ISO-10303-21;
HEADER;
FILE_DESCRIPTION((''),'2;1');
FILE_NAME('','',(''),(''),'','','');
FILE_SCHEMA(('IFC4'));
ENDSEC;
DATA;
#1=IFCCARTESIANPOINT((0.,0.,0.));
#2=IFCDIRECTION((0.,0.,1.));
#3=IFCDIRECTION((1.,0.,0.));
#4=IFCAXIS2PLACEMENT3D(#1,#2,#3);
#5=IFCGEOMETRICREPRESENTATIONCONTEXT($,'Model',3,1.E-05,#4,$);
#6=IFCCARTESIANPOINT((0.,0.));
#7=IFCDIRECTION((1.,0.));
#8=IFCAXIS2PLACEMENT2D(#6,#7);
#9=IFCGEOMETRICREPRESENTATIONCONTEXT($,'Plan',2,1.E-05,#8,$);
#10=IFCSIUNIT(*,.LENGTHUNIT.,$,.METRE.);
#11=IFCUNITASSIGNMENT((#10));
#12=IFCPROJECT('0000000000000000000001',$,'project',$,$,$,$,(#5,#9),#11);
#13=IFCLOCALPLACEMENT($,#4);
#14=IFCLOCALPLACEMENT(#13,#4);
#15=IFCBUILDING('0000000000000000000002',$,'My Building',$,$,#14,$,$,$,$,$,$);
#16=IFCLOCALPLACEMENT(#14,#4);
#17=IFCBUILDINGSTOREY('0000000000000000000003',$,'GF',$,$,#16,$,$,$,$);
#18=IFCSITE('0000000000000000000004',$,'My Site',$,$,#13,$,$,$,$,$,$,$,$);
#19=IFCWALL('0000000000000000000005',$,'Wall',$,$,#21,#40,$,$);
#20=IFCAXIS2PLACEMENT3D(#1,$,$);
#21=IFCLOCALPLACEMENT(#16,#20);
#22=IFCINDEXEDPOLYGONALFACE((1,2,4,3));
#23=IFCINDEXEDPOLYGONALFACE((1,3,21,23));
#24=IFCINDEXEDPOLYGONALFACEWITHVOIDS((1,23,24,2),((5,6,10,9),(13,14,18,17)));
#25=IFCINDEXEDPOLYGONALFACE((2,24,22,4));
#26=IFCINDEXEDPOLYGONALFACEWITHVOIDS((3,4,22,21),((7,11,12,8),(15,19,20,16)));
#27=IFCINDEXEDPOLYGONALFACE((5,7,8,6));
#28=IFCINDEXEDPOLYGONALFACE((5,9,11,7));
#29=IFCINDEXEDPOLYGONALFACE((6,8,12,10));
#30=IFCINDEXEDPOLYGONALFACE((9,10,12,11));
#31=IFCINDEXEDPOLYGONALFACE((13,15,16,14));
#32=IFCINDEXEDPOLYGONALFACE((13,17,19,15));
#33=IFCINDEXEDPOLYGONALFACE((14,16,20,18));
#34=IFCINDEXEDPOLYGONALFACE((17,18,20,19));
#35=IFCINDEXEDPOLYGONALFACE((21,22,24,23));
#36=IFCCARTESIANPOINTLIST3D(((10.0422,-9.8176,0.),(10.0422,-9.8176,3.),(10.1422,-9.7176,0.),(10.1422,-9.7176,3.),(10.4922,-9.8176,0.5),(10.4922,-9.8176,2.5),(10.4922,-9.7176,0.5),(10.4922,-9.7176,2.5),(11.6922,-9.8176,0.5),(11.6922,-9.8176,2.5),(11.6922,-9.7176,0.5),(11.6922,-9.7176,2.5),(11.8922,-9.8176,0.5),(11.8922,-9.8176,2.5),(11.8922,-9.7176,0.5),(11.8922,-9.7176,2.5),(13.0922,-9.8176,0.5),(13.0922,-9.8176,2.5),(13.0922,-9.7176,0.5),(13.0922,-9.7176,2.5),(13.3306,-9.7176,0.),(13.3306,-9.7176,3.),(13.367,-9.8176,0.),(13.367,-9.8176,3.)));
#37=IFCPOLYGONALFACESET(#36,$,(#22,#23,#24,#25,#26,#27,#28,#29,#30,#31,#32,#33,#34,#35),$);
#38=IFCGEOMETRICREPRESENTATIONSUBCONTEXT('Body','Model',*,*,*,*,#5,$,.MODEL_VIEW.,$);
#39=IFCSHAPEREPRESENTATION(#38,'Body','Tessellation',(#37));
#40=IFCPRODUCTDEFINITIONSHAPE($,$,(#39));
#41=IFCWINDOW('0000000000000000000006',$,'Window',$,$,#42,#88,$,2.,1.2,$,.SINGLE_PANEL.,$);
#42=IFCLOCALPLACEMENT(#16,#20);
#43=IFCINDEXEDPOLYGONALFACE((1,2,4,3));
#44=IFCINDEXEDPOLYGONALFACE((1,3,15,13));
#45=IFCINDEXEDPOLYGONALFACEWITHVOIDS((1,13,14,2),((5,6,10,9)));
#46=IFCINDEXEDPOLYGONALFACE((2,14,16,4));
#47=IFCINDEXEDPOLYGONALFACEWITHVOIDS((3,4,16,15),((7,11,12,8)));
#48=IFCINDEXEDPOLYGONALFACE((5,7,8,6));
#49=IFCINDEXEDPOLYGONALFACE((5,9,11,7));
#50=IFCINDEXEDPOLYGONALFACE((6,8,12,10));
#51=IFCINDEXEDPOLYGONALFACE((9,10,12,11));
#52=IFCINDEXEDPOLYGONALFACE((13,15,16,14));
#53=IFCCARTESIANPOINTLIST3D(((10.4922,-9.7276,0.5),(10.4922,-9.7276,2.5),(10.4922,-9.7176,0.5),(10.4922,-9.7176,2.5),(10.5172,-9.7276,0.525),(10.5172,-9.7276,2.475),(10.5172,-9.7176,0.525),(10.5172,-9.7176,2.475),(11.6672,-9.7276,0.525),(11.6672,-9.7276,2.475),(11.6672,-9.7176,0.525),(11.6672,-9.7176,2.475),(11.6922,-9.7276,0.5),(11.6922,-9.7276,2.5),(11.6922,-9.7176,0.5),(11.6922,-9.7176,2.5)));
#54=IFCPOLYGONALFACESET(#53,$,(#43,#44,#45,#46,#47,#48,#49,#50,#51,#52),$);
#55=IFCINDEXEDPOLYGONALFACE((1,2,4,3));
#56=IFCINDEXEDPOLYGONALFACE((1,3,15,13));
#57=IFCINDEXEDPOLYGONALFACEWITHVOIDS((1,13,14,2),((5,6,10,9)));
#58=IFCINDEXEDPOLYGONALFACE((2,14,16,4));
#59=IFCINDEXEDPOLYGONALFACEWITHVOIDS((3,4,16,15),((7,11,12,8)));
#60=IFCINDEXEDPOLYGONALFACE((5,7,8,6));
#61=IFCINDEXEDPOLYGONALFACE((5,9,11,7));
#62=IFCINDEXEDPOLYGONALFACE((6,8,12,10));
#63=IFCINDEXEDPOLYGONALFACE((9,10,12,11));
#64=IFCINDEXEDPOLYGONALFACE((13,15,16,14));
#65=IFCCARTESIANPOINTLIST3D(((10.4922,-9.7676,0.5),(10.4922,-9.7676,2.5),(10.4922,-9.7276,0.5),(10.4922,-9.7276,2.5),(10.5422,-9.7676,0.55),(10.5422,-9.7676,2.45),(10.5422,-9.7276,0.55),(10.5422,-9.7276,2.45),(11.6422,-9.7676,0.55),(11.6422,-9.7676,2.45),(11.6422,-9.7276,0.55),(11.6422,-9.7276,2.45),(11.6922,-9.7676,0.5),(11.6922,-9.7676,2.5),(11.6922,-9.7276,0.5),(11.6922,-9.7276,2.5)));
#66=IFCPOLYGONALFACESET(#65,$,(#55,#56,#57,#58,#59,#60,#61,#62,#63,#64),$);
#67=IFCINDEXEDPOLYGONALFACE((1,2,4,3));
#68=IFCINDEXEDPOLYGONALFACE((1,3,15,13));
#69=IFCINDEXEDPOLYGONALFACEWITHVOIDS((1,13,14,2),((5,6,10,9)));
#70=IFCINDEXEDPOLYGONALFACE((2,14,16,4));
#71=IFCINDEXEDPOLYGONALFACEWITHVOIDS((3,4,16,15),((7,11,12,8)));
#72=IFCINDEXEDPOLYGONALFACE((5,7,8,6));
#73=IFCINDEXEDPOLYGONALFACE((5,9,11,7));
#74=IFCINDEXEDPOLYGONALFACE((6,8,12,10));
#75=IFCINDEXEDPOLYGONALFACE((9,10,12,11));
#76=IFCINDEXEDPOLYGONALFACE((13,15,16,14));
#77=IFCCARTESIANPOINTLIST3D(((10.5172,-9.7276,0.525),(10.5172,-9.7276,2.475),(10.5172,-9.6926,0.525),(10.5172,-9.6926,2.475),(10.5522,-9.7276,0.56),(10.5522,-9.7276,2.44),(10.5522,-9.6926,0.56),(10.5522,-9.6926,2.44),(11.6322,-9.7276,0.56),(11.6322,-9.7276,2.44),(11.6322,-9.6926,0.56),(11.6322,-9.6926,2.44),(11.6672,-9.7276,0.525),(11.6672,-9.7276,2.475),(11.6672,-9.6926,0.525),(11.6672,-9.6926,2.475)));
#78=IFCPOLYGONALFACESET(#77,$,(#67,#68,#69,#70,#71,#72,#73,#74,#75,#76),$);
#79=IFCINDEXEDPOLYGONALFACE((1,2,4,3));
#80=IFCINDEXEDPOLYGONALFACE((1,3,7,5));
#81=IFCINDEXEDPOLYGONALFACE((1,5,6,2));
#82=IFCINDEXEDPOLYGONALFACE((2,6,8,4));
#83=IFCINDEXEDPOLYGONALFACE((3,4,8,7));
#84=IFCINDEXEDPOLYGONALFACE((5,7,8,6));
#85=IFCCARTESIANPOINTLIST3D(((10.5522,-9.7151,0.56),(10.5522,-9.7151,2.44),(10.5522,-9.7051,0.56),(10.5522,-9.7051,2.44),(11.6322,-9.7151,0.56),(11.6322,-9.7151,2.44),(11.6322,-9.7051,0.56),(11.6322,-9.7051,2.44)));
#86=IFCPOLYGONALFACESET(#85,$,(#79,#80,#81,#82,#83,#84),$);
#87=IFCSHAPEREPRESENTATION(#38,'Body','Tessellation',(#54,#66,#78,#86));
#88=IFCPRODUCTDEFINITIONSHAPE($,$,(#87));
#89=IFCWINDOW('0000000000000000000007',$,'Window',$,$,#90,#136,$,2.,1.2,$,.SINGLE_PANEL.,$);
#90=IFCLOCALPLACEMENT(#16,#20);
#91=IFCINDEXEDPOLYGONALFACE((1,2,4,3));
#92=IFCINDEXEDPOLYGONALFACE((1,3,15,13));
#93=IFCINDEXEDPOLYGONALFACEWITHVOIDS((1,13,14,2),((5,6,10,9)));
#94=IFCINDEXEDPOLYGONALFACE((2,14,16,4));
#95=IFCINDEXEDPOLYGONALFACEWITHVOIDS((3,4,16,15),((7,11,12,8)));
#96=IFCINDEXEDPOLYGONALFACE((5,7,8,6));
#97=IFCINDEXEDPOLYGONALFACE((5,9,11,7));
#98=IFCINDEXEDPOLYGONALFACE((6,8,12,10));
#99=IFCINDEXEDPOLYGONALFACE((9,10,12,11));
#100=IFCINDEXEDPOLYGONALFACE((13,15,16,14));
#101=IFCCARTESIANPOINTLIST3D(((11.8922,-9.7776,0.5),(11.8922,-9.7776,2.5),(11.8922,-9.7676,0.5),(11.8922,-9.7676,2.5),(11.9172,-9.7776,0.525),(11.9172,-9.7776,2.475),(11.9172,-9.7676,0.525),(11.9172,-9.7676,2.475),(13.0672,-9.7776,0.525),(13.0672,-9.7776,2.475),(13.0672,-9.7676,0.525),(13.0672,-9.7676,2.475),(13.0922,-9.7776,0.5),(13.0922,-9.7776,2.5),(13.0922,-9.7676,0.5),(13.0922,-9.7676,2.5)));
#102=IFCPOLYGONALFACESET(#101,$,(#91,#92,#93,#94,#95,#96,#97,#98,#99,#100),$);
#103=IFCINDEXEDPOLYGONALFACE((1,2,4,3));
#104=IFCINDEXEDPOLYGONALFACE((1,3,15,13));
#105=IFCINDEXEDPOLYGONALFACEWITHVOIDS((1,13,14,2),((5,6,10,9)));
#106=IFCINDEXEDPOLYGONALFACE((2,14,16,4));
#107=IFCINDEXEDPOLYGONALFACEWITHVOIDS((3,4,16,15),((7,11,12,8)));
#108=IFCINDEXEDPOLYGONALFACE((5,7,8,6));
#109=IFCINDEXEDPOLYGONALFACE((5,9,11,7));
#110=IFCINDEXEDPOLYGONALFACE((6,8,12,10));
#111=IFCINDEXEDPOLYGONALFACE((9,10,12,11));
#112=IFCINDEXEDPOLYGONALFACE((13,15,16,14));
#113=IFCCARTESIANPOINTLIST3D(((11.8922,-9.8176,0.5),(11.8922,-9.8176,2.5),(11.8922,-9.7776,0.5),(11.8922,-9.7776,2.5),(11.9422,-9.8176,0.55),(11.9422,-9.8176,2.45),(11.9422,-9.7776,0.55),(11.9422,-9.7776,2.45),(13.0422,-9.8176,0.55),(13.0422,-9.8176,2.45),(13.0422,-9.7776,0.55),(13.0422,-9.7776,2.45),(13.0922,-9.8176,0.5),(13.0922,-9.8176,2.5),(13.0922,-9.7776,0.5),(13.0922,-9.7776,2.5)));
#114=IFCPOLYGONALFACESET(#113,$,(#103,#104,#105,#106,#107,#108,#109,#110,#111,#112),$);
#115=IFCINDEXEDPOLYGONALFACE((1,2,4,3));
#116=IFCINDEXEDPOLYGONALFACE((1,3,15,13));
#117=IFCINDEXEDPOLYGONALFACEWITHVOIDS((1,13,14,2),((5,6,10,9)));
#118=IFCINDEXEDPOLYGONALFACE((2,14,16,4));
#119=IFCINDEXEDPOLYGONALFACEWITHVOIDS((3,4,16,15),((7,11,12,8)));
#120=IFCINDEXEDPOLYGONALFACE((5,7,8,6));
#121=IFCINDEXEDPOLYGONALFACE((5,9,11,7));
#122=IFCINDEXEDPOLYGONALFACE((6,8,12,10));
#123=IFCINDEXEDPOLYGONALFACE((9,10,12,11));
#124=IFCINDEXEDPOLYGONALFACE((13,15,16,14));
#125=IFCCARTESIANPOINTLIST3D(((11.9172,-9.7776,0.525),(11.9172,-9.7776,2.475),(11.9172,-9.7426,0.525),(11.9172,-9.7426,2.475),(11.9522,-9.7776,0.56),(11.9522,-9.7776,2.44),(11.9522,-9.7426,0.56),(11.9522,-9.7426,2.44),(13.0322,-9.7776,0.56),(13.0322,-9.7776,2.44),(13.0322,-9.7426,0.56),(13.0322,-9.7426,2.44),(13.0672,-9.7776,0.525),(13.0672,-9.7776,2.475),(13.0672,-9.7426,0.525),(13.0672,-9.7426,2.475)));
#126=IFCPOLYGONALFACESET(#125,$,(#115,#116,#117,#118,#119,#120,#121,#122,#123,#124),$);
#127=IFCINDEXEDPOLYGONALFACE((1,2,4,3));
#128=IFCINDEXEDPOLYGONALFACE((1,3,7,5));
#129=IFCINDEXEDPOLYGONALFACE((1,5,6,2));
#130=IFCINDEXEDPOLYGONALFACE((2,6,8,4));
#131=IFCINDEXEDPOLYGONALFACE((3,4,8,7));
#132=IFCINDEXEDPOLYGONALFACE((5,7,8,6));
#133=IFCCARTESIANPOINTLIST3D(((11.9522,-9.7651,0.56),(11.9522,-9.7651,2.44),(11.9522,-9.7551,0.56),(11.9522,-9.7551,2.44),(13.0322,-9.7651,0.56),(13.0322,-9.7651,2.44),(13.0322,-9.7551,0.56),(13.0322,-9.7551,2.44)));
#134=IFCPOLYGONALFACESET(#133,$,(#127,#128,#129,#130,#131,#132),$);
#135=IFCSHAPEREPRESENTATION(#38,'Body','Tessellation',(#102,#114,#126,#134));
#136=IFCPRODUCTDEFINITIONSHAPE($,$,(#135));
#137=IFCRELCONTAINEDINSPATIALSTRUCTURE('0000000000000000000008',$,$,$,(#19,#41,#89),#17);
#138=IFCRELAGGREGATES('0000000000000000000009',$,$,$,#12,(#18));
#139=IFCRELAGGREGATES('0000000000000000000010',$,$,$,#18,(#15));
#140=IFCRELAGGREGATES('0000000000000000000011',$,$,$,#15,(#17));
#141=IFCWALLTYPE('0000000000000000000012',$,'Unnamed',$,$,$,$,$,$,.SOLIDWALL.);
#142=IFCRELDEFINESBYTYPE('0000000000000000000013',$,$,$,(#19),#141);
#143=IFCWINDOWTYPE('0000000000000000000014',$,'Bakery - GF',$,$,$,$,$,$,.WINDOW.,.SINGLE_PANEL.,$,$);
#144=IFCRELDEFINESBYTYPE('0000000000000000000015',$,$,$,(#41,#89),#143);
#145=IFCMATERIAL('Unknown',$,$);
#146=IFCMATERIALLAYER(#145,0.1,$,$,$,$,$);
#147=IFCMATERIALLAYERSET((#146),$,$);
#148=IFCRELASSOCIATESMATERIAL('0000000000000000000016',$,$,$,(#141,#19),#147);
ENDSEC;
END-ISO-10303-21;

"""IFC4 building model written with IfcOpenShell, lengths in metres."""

from ifc_helpers import new_model, entity, si_unit, frame, origin_with_axes, origin_2d_with_axis, place, context, subcontext, project, spatial, line, indexed_curve, outline, extrude, shape, source, transform, mapped, material, layer, layer_set, layer_usage, type_object, type_shapes, element, fill, save


model = new_model("IFC4")

# Units and contexts
model_context = context("Model", 3, precision=1e-05, world=origin_with_axes())
plan_context = context("Plan", 2, precision=1e-05, world=origin_2d_with_axis())
body_context_1 = subcontext(model_context, "Body", "Model", "MODEL_VIEW")
body_context_2 = subcontext(plan_context, "Body", "Plan", "PLAN_VIEW")
ifc_project = project(units=[si_unit("LENGTHUNIT", "METRE")], contexts=[model_context, plan_context])

# Site, building, storey
site_placement = place(None, origin_with_axes())
site = spatial("IfcSite", under=ifc_project, at=site_placement, Name="My Site")
building_placement = place(site_placement, origin_with_axes())
building = spatial("IfcBuilding", under=site, at=building_placement, Name="My Building")
storey_placement = place(building_placement, origin_with_axes())
storey = spatial("IfcBuildingStorey", under=building, at=storey_placement, Name="GF")

# Shared definitions
ifc_material = material(Name="Unknown")

# Shared definitions
ifc_layer_1 = layer(ifc_material, 0.1)
ifc_layer_set_1 = layer_set([ifc_layer_1])
wall_type = type_object("IfcWallType", Name="Unnamed", PredefinedType="SOLIDWALL", material=ifc_layer_set_1)

# Wall, openings, windows
ifc_layer_usage_1 = layer_usage(ifc_layer_set_1, "AXIS2", "POSITIVE", 0.0)
wall_1_placement = place(storey_placement, frame((10.1422, -9.8176, 0.0), z_axis=(0.0, 0.0, 1.0), x_axis=(1.0, 0.0, 0.0)))
wall_1 = element("IfcWall", 1, at=wall_1_placement, inside=storey, type_object=wall_type, material=ifc_layer_usage_1, Name="Wall", context=body_context_1, shape_type="SweptSolid", body=[
    extrude(outline(indexed_curve([(-0.1, 0.0), (0.0, 0.1), (3.1883, 0.1), (3.2247, 0.0)], segments=[line(1, 2, 3, 4, 1)])), origin_with_axes(), (0.0, 0.0, 1.0), 3.0),
])
shared_shape_1 = source(origin_with_axes(), body_context_1, "Body", "SweptSolid", [
    extrude(outline(indexed_curve([(0.0, 0.0), (1.2, 0.0), (1.2, 2.0), (0.0, 2.0)], segments=[line(1, 2, 3, 4, 1)])), frame((0.0, -0.6, 0.0), z_axis=(0.0, -1.0, 0.0), x_axis=(1.0, 0.0, 0.0)), (0.0, 0.0, -1.0), 1.2),
])
opening_1_placement = place(wall_1_placement, frame((0.35, 0.0, 0.5), z_axis=(0.0, 0.0, 1.0), x_axis=(1.0, 0.0, 0.0)))
opening_1 = element("IfcOpeningElement", 2, at=opening_1_placement, cuts=wall_1, PredefinedType="OPENING", context=body_context_1, shape_type="MappedRepresentation", body=[
    mapped(shared_shape_1, transform((0.0, 0.0, 0.0), x_axis=(1.0, 0.0, 0.0), y_axis=(0.0, 1.0, 0.0), z_axis=(0.0, 0.0, 1.0), scale=1.0)),
])
opening_2_placement = place(wall_1_placement, frame((1.75, -0.05, 0.5), z_axis=(0.0, 0.0, 1.0), x_axis=(1.0, 0.0, 0.0)))
opening_2 = element("IfcOpeningElement", 3, at=opening_2_placement, cuts=wall_1, PredefinedType="OPENING", context=body_context_1, shape_type="MappedRepresentation", body=[
    mapped(shared_shape_1, transform((0.0, 0.0, 0.0), x_axis=(1.0, 0.0, 0.0), y_axis=(0.0, 1.0, 0.0), z_axis=(0.0, 0.0, 1.0), scale=1.0)),
])
window_type = type_object("IfcWindowType", Name="Bakery - GF", PartitioningType="SINGLE_PANEL", PredefinedType="WINDOW")
shared_shape_2 = source(origin_with_axes(), body_context_1, "Body", "SweptSolid", [
    extrude(outline(indexed_curve([(0.0, 0.0), (1.2, 0.0), (1.2, 2.0), (0.0, 2.0)], segments=[line(1, 2, 3, 4, 1)]), holes=[indexed_curve([(0.025, 0.025), (1.175, 0.025), (1.175, 1.975), (0.025, 1.975)], segments=[line(1, 2, 3, 4, 1)])]), frame((0.0, 0.09, 0.0), z_axis=(0.0, -1.0, 0.0), x_axis=(1.0, 0.0, 0.0)), (0.0, 0.0, -1.0), 0.01),
    extrude(outline(indexed_curve([(0.0, 0.0), (1.2, 0.0), (1.2, 2.0), (0.0, 2.0)], segments=[line(1, 2, 3, 4, 1)]), holes=[indexed_curve([(0.05, 0.05), (1.15, 0.05), (1.15, 1.95), (0.05, 1.95)], segments=[line(1, 2, 3, 4, 1)])]), frame((0.0, 0.05, 0.0), z_axis=(0.0, -1.0, 0.0), x_axis=(1.0, 0.0, 0.0)), (0.0, 0.0, -1.0), 0.04),
    extrude(outline(indexed_curve([(0.0, 0.0), (1.15, 0.0), (1.15, 1.95), (0.0, 1.95)], segments=[line(1, 2, 3, 4, 1)]), holes=[indexed_curve([(0.035, 0.035), (1.115, 0.035), (1.115, 1.915), (0.035, 1.915)], segments=[line(1, 2, 3, 4, 1)])]), frame((0.025, 0.09, 0.025), z_axis=(0.0, -1.0, 0.0), x_axis=(1.0, 0.0, 0.0)), (0.0, 0.0, -1.0), 0.035),
    extrude(outline(indexed_curve([(0.035, 0.035), (1.115, 0.035), (1.115, 1.915), (0.035, 1.915)], segments=[line(1, 2, 3, 4, 1)])), frame((0.025, 0.1025, 0.025), z_axis=(0.0, -1.0, 0.0), x_axis=(1.0, 0.0, 0.0)), (0.0, 0.0, -1.0), 0.01),
])
shared_shape_3 = source(origin_with_axes(), body_context_2, "Body", "Curve2D", [
    entity("IfcIndexedPolyCurve", entity("IfcCartesianPointList2D", [[0.05, 0.05], [1.15, 0.05]])),
    entity("IfcIndexedPolyCurve", entity("IfcCartesianPointList2D", [[0.0, 0.1], [0.025, 0.1], [0.025, 0.09], [0.05, 0.09], [0.05, 0.05], [0.0, 0.05]]), [entity("IfcLineIndex", [1, 2, 3, 4, 5, 6, 1])]),
    entity("IfcIndexedPolyCurve", entity("IfcCartesianPointList2D", [[1.2, 0.1], [1.175, 0.1], [1.175, 0.09], [1.15, 0.09], [1.15, 0.05], [1.2, 0.05]]), [entity("IfcLineIndex", [1, 2, 3, 4, 5, 6, 1])]),
    entity("IfcIndexedPolyCurve", entity("IfcCartesianPointList2D", [[0.025, 0.09], [0.06, 0.09], [0.06, 0.125], [0.025, 0.125]]), [entity("IfcLineIndex", [1, 2, 3, 4, 1])]),
    entity("IfcIndexedPolyCurve", entity("IfcCartesianPointList2D", [[1.175, 0.09], [1.14, 0.09], [1.14, 0.125], [1.175, 0.125]]), [entity("IfcLineIndex", [1, 2, 3, 4, 1])]),
    entity("IfcIndexedPolyCurve", entity("IfcCartesianPointList2D", [[0.06, 0.09], [1.14, 0.09]])),
    entity("IfcIndexedPolyCurve", entity("IfcCartesianPointList2D", [[0.06, 0.125], [1.14, 0.125]])),
    entity("IfcIndexedPolyCurve", entity("IfcCartesianPointList2D", [[0.06, 0.1075], [1.14, 0.1075]])),
])
type_shapes(window_type, [shared_shape_2, shared_shape_3])
window_1_placement = place(opening_1_placement, origin_with_axes())
window_1 = element("IfcWindow", 4, at=window_1_placement, inside=storey, type_object=window_type, Name="Window", OverallHeight=2.0, OverallWidth=1.2, PartitioningType="SINGLE_PANEL", shapes=[
    shape(body_context_1, "Body", "MappedRepresentation", [mapped(shared_shape_2, transform((0.0, 0.0, 0.0), x_axis=(1.0, 0.0, 0.0), y_axis=(0.0, 1.0, 0.0), z_axis=(0.0, 0.0, 1.0), scale=1.0))]),
    shape(body_context_2, "Body", "MappedRepresentation", [mapped(shared_shape_3, transform((0.0, 0.0, 0.0), x_axis=(1.0, 0.0, 0.0), y_axis=(0.0, 1.0, 0.0), z_axis=(0.0, 0.0, 1.0), scale=1.0))]),
])
fill(opening_1, window_1)
window_2_placement = place(opening_2_placement, origin_with_axes())
window_2 = element("IfcWindow", 5, at=window_2_placement, inside=storey, type_object=window_type, Name="Window", OverallHeight=2.0, OverallWidth=1.2, PartitioningType="SINGLE_PANEL", shapes=[
    shape(body_context_1, "Body", "MappedRepresentation", [mapped(shared_shape_2, transform((0.0, 0.0, 0.0), x_axis=(1.0, 0.0, 0.0), y_axis=(0.0, 1.0, 0.0), z_axis=(0.0, 0.0, 1.0), scale=1.0))]),
    shape(body_context_2, "Body", "MappedRepresentation", [mapped(shared_shape_3, transform((0.0, 0.0, 0.0), x_axis=(1.0, 0.0, 0.0), y_axis=(0.0, 1.0, 0.0), z_axis=(0.0, 0.0, 1.0), scale=1.0))]),
])
fill(opening_2, window_2)

save(model, "model.ifc")
